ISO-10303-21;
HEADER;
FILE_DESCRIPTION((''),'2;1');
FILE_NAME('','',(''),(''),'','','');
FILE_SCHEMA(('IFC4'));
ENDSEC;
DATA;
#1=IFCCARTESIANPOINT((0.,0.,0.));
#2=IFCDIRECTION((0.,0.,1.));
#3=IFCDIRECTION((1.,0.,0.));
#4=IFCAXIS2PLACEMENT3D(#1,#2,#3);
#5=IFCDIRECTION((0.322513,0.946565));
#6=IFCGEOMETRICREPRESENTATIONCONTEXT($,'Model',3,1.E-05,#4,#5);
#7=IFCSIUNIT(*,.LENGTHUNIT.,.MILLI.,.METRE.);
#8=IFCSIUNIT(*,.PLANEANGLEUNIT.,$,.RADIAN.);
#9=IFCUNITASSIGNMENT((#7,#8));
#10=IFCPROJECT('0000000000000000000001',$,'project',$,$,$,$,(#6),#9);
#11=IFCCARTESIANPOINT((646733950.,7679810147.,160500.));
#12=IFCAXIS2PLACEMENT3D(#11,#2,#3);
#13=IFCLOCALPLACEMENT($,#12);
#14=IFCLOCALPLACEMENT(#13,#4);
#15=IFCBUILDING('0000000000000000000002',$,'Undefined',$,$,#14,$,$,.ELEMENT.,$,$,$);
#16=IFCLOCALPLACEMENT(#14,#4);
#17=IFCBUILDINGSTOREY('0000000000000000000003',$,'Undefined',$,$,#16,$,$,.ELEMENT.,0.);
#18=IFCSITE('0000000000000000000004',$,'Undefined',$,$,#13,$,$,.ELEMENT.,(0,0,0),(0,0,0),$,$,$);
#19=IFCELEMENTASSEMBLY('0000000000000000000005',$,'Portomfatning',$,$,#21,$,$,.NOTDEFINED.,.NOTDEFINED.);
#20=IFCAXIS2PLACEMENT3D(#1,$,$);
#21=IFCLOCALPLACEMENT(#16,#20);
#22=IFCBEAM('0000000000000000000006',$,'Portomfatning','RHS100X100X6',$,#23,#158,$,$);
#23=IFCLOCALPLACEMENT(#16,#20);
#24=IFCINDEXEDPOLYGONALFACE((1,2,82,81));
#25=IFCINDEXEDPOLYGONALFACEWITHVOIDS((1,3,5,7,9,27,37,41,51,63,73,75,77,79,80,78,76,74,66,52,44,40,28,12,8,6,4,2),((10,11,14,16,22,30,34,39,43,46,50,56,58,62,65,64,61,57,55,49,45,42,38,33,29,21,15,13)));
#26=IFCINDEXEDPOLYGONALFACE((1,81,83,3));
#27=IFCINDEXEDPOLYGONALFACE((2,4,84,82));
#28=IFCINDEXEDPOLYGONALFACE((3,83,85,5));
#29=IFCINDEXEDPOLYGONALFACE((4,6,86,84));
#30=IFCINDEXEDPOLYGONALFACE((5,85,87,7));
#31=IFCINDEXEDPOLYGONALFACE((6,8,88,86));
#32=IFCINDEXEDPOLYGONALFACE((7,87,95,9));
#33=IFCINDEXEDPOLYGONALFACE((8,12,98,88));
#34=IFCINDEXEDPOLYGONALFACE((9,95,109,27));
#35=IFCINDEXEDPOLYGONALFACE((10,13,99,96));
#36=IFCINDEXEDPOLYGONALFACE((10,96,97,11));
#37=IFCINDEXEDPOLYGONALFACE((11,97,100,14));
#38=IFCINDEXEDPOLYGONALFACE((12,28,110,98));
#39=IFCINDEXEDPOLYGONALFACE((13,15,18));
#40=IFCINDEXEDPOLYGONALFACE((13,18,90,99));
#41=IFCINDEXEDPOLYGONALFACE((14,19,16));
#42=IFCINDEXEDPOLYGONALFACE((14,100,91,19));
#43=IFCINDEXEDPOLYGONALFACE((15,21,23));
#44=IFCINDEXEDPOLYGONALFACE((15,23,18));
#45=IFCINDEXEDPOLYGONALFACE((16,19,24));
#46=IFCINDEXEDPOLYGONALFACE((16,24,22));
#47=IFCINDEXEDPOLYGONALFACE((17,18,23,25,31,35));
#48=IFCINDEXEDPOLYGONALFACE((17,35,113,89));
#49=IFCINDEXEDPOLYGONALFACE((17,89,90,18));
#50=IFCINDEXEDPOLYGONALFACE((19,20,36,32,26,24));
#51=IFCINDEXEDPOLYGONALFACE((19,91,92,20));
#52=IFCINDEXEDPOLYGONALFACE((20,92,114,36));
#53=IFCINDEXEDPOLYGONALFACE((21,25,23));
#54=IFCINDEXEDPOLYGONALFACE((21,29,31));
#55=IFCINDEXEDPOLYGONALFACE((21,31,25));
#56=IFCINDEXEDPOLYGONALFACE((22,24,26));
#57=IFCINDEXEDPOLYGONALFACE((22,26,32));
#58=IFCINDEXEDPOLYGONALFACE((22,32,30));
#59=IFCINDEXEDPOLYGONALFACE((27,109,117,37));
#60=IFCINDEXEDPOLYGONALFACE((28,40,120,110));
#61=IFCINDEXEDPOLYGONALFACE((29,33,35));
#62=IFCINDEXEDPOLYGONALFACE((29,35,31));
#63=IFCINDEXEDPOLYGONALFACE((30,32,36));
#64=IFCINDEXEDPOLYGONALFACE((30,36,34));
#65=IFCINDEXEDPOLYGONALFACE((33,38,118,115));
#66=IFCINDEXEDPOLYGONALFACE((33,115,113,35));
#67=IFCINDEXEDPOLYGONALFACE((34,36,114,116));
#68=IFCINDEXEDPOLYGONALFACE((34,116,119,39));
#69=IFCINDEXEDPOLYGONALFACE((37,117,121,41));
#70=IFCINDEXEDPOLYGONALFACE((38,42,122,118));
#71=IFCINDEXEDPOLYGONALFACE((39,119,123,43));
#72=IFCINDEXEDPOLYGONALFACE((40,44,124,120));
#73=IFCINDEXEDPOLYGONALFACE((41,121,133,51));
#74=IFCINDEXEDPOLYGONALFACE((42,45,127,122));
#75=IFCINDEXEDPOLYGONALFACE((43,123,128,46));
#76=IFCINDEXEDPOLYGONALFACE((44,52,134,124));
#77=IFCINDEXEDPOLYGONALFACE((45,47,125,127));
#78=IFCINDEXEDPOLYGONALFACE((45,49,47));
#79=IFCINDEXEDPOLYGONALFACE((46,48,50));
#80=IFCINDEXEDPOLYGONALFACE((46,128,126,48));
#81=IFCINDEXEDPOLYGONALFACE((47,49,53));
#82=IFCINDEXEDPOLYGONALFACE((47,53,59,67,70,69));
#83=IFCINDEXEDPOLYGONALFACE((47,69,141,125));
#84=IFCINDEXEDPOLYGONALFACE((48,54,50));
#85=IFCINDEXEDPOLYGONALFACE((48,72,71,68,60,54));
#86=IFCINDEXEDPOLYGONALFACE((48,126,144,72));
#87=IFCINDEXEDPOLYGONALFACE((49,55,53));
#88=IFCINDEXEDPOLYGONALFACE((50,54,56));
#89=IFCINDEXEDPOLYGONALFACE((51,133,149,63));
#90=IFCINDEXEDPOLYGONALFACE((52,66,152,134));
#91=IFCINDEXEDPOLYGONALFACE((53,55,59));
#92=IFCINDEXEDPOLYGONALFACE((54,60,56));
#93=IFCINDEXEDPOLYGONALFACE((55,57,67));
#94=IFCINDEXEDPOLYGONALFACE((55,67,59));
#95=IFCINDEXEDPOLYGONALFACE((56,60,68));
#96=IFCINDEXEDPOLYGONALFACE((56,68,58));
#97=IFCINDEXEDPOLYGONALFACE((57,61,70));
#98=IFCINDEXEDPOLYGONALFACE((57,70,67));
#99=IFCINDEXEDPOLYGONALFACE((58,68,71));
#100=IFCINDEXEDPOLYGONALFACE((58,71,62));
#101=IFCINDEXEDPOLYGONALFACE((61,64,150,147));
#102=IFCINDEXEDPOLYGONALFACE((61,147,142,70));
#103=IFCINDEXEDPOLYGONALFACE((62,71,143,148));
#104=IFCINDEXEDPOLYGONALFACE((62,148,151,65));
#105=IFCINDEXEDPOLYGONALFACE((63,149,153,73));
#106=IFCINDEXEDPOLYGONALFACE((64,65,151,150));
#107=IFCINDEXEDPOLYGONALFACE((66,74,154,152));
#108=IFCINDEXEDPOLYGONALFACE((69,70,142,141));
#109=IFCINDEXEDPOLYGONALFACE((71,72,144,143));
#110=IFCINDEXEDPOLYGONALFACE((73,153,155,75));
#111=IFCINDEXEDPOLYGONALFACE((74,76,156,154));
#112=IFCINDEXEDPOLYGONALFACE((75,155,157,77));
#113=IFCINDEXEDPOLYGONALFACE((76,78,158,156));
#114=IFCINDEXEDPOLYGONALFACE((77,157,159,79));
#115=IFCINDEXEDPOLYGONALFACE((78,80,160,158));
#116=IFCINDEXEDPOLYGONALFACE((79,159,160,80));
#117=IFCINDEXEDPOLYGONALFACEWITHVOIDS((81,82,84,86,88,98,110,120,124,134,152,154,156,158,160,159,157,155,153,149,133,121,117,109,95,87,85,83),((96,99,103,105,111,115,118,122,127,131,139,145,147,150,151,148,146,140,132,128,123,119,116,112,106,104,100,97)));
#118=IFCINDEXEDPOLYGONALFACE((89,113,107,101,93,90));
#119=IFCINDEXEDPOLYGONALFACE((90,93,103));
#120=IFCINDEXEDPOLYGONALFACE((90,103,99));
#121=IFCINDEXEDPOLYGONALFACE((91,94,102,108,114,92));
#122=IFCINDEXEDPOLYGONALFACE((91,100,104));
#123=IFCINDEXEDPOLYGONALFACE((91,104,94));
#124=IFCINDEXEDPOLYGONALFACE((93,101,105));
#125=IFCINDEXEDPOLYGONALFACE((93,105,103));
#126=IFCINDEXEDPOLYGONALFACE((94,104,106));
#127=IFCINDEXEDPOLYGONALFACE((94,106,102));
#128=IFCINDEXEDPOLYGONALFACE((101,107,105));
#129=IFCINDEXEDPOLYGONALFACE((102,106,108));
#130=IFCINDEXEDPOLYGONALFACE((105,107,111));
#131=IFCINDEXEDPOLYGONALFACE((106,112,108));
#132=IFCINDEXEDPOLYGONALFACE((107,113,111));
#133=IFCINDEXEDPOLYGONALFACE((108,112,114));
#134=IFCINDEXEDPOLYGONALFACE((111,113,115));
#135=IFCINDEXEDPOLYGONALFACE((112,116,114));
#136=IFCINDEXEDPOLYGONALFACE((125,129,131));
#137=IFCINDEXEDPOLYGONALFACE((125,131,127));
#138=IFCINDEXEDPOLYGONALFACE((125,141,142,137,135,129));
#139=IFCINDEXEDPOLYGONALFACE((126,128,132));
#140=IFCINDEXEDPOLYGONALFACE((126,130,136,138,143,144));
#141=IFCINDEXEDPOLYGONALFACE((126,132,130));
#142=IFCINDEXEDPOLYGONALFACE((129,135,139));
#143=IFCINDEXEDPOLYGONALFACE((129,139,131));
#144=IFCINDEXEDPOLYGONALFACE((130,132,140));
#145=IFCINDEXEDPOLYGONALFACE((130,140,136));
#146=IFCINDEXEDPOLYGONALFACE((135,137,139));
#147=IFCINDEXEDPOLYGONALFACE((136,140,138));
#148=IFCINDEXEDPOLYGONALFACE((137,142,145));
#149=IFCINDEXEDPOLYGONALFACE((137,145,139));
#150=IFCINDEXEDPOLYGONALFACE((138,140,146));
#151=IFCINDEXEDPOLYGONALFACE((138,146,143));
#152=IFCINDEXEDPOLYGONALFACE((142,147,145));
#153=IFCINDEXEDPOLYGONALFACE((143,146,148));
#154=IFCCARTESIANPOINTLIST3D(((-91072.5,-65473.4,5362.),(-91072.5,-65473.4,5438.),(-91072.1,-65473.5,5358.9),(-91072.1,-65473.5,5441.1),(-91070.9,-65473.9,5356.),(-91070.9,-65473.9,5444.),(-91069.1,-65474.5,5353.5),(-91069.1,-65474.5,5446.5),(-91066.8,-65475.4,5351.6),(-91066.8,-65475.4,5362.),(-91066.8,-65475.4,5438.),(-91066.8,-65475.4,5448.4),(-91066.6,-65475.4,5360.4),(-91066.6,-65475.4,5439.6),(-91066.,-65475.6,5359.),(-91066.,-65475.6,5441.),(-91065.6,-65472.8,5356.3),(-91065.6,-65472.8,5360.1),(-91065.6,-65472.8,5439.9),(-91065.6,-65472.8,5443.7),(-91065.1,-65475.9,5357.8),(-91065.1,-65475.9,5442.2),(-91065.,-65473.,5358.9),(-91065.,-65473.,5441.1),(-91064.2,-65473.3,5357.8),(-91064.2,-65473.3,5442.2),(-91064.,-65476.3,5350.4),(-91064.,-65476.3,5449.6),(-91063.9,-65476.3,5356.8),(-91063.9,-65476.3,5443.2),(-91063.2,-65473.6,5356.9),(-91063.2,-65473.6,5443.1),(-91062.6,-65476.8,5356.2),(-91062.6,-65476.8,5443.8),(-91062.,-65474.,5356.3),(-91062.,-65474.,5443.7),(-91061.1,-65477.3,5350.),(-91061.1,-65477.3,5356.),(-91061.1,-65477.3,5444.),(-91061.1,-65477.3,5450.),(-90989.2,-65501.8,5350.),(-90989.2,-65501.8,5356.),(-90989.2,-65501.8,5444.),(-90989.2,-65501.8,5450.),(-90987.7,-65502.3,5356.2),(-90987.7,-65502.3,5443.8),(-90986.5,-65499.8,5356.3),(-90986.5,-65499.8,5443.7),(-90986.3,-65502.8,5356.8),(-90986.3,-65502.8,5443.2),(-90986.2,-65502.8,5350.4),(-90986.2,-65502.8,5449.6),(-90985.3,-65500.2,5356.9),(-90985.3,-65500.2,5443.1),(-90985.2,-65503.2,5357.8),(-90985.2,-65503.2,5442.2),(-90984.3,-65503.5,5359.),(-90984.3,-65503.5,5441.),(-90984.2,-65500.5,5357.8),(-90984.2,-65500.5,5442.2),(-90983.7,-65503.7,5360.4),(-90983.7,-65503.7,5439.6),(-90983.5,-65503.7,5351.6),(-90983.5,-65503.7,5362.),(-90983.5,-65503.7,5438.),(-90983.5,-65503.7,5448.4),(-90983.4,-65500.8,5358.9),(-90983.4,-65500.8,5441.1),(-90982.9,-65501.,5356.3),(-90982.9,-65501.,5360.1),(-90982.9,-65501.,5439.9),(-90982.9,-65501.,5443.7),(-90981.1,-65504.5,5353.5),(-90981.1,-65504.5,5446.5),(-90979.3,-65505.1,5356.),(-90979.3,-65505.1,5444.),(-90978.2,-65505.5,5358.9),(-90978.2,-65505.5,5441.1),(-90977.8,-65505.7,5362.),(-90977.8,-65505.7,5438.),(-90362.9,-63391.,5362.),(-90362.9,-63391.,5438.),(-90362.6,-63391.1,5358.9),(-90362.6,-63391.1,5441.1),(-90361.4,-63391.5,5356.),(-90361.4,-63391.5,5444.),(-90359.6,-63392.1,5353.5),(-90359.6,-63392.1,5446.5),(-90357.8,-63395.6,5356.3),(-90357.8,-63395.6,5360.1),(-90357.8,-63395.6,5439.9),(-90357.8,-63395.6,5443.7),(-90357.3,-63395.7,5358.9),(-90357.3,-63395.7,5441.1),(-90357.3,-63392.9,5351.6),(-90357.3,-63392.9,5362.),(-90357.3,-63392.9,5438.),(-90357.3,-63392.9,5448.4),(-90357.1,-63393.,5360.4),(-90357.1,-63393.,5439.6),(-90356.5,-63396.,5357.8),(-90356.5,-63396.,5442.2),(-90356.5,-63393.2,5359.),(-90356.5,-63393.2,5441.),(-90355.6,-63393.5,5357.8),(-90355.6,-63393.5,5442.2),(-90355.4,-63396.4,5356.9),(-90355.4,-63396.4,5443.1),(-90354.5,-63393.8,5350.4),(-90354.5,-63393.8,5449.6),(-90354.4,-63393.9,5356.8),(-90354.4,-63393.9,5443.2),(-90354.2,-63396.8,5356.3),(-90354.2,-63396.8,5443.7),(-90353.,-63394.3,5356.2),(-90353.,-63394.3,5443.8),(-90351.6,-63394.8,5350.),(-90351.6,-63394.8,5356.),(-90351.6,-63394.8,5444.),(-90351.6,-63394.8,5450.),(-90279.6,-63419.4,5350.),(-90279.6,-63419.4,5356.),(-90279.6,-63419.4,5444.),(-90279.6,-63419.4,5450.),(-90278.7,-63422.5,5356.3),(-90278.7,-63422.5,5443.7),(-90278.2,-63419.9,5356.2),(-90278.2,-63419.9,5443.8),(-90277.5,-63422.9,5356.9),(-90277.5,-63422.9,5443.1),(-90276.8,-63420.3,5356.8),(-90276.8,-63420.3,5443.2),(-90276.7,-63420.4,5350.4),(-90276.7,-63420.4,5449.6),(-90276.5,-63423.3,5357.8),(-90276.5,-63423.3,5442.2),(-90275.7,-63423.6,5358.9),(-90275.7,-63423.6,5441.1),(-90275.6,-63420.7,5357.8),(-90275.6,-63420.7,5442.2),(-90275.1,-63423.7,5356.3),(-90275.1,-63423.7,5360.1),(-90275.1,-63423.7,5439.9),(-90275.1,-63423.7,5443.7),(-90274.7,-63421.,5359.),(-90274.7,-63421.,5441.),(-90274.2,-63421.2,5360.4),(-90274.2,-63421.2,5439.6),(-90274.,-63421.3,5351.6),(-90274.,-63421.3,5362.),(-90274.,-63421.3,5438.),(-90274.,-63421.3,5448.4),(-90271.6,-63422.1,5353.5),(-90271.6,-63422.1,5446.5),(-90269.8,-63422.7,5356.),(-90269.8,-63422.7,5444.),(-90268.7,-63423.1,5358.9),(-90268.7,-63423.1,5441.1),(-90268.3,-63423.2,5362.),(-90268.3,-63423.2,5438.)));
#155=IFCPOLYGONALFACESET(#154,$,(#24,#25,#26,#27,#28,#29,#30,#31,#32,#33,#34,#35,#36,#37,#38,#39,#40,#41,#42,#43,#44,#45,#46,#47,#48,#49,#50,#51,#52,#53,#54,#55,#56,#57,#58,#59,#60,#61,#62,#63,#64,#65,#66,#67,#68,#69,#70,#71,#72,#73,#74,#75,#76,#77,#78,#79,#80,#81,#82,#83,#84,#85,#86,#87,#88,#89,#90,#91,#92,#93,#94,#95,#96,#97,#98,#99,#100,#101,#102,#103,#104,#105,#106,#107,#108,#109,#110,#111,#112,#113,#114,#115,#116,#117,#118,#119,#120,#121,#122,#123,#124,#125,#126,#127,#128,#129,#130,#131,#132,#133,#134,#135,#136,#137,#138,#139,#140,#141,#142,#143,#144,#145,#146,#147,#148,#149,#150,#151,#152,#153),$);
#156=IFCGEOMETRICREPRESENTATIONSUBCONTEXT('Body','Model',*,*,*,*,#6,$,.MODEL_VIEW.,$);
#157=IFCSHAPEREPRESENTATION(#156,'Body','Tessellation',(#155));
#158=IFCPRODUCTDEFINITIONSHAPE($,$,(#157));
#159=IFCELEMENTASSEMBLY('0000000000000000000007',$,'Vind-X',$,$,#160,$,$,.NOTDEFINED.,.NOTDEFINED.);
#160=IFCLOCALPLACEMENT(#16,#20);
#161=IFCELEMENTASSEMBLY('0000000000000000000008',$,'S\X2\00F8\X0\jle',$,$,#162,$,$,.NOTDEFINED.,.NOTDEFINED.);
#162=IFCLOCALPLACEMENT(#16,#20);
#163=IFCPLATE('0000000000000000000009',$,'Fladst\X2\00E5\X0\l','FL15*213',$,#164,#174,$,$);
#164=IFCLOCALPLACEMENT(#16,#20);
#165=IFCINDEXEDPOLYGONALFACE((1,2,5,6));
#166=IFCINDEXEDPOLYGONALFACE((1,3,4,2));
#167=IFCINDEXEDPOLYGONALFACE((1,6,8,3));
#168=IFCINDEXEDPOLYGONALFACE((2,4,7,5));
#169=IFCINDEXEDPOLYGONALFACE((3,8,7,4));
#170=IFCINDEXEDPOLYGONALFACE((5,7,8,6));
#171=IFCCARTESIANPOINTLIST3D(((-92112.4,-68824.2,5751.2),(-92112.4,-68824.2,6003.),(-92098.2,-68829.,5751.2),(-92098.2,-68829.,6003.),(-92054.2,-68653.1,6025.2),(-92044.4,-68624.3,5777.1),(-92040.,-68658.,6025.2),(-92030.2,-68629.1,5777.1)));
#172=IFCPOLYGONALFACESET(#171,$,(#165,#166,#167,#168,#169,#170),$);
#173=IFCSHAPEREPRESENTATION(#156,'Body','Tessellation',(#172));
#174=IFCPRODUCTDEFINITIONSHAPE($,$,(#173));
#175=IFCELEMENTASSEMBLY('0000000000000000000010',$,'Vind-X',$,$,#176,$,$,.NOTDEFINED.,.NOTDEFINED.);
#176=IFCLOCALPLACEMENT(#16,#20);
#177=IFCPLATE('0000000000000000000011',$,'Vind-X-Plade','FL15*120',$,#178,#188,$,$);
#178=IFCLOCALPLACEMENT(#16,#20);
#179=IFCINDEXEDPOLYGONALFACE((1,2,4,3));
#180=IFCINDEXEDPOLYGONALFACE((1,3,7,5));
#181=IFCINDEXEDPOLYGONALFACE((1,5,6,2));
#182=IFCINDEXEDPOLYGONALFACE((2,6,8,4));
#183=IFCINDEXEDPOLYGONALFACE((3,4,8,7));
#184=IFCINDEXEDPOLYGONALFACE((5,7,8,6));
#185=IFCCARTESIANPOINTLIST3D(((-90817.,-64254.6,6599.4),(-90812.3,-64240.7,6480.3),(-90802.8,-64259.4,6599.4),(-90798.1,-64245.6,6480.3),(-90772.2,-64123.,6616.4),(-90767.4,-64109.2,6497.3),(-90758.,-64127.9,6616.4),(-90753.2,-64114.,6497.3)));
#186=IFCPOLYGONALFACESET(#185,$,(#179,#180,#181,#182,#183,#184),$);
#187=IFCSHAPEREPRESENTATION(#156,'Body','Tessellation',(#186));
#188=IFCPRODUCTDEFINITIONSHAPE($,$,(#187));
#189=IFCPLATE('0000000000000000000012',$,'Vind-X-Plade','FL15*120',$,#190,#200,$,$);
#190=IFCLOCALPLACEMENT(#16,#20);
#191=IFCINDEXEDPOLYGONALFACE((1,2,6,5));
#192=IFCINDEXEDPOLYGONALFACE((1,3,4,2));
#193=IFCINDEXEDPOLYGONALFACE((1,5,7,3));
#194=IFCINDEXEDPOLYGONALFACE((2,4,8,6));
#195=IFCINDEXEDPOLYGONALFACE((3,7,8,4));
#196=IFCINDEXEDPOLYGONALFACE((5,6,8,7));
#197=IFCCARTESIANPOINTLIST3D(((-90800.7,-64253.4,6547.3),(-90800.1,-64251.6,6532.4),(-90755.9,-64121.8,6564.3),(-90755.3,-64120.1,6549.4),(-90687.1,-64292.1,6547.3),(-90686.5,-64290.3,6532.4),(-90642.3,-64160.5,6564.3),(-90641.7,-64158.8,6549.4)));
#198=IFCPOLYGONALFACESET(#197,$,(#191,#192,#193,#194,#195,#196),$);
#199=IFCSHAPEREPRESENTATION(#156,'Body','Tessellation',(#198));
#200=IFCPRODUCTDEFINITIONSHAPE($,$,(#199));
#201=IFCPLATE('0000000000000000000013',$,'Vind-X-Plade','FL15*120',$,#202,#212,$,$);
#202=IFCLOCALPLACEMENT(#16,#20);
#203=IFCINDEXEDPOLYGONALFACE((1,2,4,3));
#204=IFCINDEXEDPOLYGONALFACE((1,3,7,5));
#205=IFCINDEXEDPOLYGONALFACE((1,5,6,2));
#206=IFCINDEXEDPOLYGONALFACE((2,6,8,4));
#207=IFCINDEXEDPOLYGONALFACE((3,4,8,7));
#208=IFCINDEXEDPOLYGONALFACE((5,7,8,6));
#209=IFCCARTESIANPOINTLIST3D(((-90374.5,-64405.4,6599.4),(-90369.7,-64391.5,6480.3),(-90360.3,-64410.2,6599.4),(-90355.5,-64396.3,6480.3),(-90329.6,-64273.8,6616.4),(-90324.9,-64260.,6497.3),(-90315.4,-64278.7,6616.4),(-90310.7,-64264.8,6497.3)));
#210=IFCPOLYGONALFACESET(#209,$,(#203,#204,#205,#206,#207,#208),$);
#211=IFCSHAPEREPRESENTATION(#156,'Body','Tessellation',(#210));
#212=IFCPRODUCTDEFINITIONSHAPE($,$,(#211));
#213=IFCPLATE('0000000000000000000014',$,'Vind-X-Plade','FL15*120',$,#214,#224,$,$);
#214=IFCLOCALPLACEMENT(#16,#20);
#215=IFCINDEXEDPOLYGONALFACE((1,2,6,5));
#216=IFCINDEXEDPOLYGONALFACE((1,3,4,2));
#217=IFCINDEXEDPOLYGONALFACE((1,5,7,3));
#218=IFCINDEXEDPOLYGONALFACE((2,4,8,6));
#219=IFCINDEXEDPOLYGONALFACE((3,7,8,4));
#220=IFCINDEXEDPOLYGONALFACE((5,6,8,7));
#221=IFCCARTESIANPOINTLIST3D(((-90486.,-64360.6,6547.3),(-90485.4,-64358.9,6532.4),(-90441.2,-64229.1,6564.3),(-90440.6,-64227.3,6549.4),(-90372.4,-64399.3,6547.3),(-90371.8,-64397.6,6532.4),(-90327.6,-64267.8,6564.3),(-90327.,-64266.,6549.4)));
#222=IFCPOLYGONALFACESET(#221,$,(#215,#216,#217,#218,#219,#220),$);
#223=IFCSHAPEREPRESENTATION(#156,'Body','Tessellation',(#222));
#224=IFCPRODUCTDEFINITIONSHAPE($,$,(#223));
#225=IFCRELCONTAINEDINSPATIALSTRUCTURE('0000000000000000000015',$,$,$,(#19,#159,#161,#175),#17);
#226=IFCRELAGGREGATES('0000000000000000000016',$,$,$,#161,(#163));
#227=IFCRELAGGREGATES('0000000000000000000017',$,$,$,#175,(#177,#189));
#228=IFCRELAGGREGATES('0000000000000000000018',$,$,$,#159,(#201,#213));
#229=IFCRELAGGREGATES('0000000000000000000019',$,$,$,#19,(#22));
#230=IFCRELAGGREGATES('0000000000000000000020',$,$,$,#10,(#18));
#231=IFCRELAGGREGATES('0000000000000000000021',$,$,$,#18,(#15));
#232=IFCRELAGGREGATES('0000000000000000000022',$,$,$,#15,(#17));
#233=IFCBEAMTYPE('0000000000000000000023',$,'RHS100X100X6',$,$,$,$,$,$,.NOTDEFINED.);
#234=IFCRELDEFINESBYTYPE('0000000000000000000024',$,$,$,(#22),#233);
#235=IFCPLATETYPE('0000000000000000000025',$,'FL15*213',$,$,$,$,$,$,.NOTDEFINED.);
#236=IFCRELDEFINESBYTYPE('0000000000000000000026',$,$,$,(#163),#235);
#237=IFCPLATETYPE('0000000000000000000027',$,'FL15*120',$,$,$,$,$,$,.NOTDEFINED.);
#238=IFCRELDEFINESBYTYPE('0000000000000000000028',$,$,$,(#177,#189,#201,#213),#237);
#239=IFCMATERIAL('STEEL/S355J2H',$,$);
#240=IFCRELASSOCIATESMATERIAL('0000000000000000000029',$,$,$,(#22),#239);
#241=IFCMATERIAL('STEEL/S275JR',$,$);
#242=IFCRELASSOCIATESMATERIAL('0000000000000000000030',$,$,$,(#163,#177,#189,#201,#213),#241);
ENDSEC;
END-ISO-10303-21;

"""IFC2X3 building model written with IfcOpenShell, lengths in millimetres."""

from ifc_helpers import new_model, si_unit, direction, frame, origin_with_axes, origin_2d_with_axis, place, context, subcontext, project, spatial, polyline, rectangle, hollow_rectangle, outline, extrude, boolean, halfspace, material, type_object, element, aggregate, save


model = new_model("IFC2X3")

# Units and contexts
model_context = context("Model", 3, precision=1e-05, world=origin_with_axes(), true_north=direction((0.322513, 0.946565)))
body_context = subcontext(model_context, "Body", "Model", "MODEL_VIEW")
ifc_project = project(units=[si_unit("LENGTHUNIT", "METRE", prefix="MILLI"), si_unit("PLANEANGLEUNIT", "RADIAN")], contexts=[model_context])

# Site, building, storey
site_placement = place(None, frame((646733950.0, 7679810147.0, 160500.0), z_axis=(0.0, 0.0, 1.0), x_axis=(1.0, 0.0, 0.0)))
site = spatial("IfcSite", under=ifc_project, at=site_placement, Name="Undefined", CompositionType="ELEMENT", RefLatitude=(0, 0, 0), RefLongitude=(0, 0, 0))
building_placement = place(site_placement, origin_with_axes())
building = spatial("IfcBuilding", under=site, at=building_placement, Name="Undefined", CompositionType="ELEMENT")
storey_placement = place(building_placement, origin_with_axes())
storey = spatial("IfcBuildingStorey", under=building, at=storey_placement, Name="Undefined", CompositionType="ELEMENT", Elevation=0.0)

# Shared definitions
ifc_material_1 = material(Name="STEEL/S355J2H")

# Element assemblies, beam
assembly_1_placement = place(storey_placement, origin_with_axes())
assembly_1 = element("IfcElementAssembly", 1, at=assembly_1_placement, inside=storey, Name="Portomfatning", AssemblyPlace="NOTDEFINED", PredefinedType="NOTDEFINED")
beam_type_1 = type_object("IfcBeamType", Name="RHS100X100X6", PredefinedType="NOTDEFINED")
beam_1_placement = place(assembly_1_placement, frame((-90312.4, -63397.6, 5400.0), z_axis=(0.946565, -0.322513, 0.0), x_axis=(-0.322513, -0.946565, 0.0)))
beam_1 = element("IfcBeam", 2, at=beam_1_placement, type_object=beam_type_1, material=ifc_material_1, Name="Portomfatning", Description="RHS100X100X6", context=body_context, shape_type="CSG", body=[
    boolean("DIFFERENCE", boolean("DIFFERENCE", boolean("DIFFERENCE", extrude(hollow_rectangle(XDim=100.0, YDim=100.0, WallThickness=6.0, InnerFilletRadius=6.0, OuterFilletRadius=12.0, at=origin_2d_with_axis()), frame((2271.7, 0.0, 0.0), z_axis=(-1.0, 0.0, 0.0), x_axis=(0.0, -1.0, 0.0)), (0.0, 0.0, 1.0), 2323.3), extrude(rectangle(XDim=87.4, YDim=87.4, at=origin_2d_with_axis()), frame((2207.2, 0.0, 0.0), z_axis=(-1.0, 0.0, 0.0), x_axis=(0.0, -1.0, 0.0)), (0.0, 0.0, 1.0), 2194.5)), halfspace(frame((2210.0, 50.0, 0.0), z_axis=(-1.0, 0.0, 0.0), x_axis=(0.0, 0.0, 1.0)), True)), halfspace(frame((10.0, 50.0, 0.0), z_axis=(1.0, 0.0, 0.0), x_axis=(0.0, 0.0, -1.0)), True)),
])
assembly_2_placement = place(storey_placement, origin_with_axes())
assembly_2 = element("IfcElementAssembly", 3, at=assembly_2_placement, inside=storey, Name="Vind-X", AssemblyPlace="NOTDEFINED", PredefinedType="NOTDEFINED")

# Element assembly, plate
assembly_3_placement = place(storey_placement, origin_with_axes())
assembly_3 = element("IfcElementAssembly", 4, at=assembly_3_placement, inside=storey, Name="Søjle", AssemblyPlace="NOTDEFINED", PredefinedType="NOTDEFINED")
ifc_material_2 = material(Name="STEEL/S275JR")
plate_type_1 = type_object("IfcPlateType", Name="FL15*213", PredefinedType="NOTDEFINED")
plate_1_placement = place(assembly_3_placement, frame((-92105.3, -68826.6, 6003.0), z_axis=(0.946565, -0.322513, 0.0), x_axis=(0.0, 0.0, -1.0)))
plate_1 = element("IfcPlate", 5, at=plate_1_placement, type_object=plate_type_1, material=ifc_material_2, Name="Fladstål", Description="FL15*213", context=body_context, shape_type="SweptSolid", body=[
    extrude(outline(polyline([(0.0, 0.0), (251.9, 0.0), (226.0, 211.1), (-22.2, 180.7), (0.0, 0.0)])), frame((0.0, 0.0, -7.5), z_axis=(0.0, 0.0, 1.0), x_axis=(1.0, 0.0, 0.0)), (0.0, 0.0, 1.0), 15.0),
])

# Element assembly, plates
assembly_4_placement = place(storey_placement, origin_with_axes())
assembly_4 = element("IfcElementAssembly", 6, at=assembly_4_placement, inside=storey, Name="Vind-X", AssemblyPlace="NOTDEFINED", PredefinedType="NOTDEFINED")
plate_type_2 = type_object("IfcPlateType", Name="FL15*120", PredefinedType="NOTDEFINED")
plate_2_placement = place(assembly_4_placement, frame((-90805.2, -64243.2, 6480.3), z_axis=(0.946565, -0.322513, 0.0), x_axis=(0.320109, 0.93951, 0.121869)))
plate_2 = element("IfcPlate", 7, at=plate_2_placement, type_object=plate_type_2, material=ifc_material_2, Name="Vind-X-Plade", Description="FL15*120", context=body_context, shape_type="SweptSolid", body=[
    extrude(outline(polyline([(0.0, 0.0), (140.0, 0.0), (140.0, 120.0), (0.0, 120.0), (0.0, 0.0)])), frame((0.0, 0.0, -7.5), z_axis=(0.0, 0.0, 1.0), x_axis=(1.0, 0.0, 0.0)), (0.0, 0.0, 1.0), 15.0),
])
plate_3_placement = place(assembly_4_placement, frame((-90664.4, -64225.4, 6548.4), z_axis=(0.039304, 0.115357, -0.992546), x_axis=(-0.946565, 0.322513, 0.0)))
plate_3 = element("IfcPlate", 8, at=plate_3_placement, type_object=plate_type_2, material=ifc_material_2, Name="Vind-X-Plade", Description="FL15*120", context=body_context, shape_type="SweptSolid", body=[
    extrude(outline(polyline([(0.0, -70.0), (0.0, 70.0), (120.0, 70.0), (120.0, -70.0), (0.0, -70.0)])), frame((0.0, 0.0, -7.5), z_axis=(0.0, 0.0, 1.0), x_axis=(1.0, 0.0, 0.0)), (0.0, 0.0, 1.0), 15.0),
])

# Plates
plate_4_placement = place(assembly_2_placement, frame((-90317.8, -64262.4, 6497.3), z_axis=(-0.946565, 0.322513, 0.0), x_axis=(-0.320109, -0.93951, -0.121869)))
plate_4 = element("IfcPlate", 9, at=plate_4_placement, type_object=plate_type_2, material=ifc_material_2, Name="Vind-X-Plade", Description="FL15*120", context=body_context, shape_type="SweptSolid", body=[
    extrude(outline(polyline([(0.0, 0.0), (140.0, 0.0), (140.0, 120.0), (0.0, 120.0), (0.0, 0.0)])), frame((0.0, 0.0, -7.5), z_axis=(0.0, 0.0, 1.0), x_axis=(1.0, 0.0, 0.0)), (0.0, 0.0, 1.0), 15.0),
])
plate_5_placement = place(assembly_2_placement, frame((-90463.3, -64294.0, 6548.4), z_axis=(0.039304, 0.115357, -0.992546), x_axis=(0.946565, -0.322513, 0.0)))
plate_5 = element("IfcPlate", 10, at=plate_5_placement, type_object=plate_type_2, material=ifc_material_2, Name="Vind-X-Plade", Description="FL15*120", context=body_context, shape_type="SweptSolid", body=[
    extrude(outline(polyline([(0.0, -70.0), (0.0, 70.0), (120.0, 70.0), (120.0, -70.0), (0.0, -70.0)])), frame((0.0, 0.0, -7.5), z_axis=(0.0, 0.0, 1.0), x_axis=(1.0, 0.0, 0.0)), (0.0, 0.0, 1.0), 15.0),
])

aggregate(assembly_3, [plate_1])

aggregate(assembly_4, [plate_2, plate_3])

aggregate(assembly_2, [plate_4, plate_5])
aggregate(assembly_1, [beam_1])

save(model, "model.ifc")
